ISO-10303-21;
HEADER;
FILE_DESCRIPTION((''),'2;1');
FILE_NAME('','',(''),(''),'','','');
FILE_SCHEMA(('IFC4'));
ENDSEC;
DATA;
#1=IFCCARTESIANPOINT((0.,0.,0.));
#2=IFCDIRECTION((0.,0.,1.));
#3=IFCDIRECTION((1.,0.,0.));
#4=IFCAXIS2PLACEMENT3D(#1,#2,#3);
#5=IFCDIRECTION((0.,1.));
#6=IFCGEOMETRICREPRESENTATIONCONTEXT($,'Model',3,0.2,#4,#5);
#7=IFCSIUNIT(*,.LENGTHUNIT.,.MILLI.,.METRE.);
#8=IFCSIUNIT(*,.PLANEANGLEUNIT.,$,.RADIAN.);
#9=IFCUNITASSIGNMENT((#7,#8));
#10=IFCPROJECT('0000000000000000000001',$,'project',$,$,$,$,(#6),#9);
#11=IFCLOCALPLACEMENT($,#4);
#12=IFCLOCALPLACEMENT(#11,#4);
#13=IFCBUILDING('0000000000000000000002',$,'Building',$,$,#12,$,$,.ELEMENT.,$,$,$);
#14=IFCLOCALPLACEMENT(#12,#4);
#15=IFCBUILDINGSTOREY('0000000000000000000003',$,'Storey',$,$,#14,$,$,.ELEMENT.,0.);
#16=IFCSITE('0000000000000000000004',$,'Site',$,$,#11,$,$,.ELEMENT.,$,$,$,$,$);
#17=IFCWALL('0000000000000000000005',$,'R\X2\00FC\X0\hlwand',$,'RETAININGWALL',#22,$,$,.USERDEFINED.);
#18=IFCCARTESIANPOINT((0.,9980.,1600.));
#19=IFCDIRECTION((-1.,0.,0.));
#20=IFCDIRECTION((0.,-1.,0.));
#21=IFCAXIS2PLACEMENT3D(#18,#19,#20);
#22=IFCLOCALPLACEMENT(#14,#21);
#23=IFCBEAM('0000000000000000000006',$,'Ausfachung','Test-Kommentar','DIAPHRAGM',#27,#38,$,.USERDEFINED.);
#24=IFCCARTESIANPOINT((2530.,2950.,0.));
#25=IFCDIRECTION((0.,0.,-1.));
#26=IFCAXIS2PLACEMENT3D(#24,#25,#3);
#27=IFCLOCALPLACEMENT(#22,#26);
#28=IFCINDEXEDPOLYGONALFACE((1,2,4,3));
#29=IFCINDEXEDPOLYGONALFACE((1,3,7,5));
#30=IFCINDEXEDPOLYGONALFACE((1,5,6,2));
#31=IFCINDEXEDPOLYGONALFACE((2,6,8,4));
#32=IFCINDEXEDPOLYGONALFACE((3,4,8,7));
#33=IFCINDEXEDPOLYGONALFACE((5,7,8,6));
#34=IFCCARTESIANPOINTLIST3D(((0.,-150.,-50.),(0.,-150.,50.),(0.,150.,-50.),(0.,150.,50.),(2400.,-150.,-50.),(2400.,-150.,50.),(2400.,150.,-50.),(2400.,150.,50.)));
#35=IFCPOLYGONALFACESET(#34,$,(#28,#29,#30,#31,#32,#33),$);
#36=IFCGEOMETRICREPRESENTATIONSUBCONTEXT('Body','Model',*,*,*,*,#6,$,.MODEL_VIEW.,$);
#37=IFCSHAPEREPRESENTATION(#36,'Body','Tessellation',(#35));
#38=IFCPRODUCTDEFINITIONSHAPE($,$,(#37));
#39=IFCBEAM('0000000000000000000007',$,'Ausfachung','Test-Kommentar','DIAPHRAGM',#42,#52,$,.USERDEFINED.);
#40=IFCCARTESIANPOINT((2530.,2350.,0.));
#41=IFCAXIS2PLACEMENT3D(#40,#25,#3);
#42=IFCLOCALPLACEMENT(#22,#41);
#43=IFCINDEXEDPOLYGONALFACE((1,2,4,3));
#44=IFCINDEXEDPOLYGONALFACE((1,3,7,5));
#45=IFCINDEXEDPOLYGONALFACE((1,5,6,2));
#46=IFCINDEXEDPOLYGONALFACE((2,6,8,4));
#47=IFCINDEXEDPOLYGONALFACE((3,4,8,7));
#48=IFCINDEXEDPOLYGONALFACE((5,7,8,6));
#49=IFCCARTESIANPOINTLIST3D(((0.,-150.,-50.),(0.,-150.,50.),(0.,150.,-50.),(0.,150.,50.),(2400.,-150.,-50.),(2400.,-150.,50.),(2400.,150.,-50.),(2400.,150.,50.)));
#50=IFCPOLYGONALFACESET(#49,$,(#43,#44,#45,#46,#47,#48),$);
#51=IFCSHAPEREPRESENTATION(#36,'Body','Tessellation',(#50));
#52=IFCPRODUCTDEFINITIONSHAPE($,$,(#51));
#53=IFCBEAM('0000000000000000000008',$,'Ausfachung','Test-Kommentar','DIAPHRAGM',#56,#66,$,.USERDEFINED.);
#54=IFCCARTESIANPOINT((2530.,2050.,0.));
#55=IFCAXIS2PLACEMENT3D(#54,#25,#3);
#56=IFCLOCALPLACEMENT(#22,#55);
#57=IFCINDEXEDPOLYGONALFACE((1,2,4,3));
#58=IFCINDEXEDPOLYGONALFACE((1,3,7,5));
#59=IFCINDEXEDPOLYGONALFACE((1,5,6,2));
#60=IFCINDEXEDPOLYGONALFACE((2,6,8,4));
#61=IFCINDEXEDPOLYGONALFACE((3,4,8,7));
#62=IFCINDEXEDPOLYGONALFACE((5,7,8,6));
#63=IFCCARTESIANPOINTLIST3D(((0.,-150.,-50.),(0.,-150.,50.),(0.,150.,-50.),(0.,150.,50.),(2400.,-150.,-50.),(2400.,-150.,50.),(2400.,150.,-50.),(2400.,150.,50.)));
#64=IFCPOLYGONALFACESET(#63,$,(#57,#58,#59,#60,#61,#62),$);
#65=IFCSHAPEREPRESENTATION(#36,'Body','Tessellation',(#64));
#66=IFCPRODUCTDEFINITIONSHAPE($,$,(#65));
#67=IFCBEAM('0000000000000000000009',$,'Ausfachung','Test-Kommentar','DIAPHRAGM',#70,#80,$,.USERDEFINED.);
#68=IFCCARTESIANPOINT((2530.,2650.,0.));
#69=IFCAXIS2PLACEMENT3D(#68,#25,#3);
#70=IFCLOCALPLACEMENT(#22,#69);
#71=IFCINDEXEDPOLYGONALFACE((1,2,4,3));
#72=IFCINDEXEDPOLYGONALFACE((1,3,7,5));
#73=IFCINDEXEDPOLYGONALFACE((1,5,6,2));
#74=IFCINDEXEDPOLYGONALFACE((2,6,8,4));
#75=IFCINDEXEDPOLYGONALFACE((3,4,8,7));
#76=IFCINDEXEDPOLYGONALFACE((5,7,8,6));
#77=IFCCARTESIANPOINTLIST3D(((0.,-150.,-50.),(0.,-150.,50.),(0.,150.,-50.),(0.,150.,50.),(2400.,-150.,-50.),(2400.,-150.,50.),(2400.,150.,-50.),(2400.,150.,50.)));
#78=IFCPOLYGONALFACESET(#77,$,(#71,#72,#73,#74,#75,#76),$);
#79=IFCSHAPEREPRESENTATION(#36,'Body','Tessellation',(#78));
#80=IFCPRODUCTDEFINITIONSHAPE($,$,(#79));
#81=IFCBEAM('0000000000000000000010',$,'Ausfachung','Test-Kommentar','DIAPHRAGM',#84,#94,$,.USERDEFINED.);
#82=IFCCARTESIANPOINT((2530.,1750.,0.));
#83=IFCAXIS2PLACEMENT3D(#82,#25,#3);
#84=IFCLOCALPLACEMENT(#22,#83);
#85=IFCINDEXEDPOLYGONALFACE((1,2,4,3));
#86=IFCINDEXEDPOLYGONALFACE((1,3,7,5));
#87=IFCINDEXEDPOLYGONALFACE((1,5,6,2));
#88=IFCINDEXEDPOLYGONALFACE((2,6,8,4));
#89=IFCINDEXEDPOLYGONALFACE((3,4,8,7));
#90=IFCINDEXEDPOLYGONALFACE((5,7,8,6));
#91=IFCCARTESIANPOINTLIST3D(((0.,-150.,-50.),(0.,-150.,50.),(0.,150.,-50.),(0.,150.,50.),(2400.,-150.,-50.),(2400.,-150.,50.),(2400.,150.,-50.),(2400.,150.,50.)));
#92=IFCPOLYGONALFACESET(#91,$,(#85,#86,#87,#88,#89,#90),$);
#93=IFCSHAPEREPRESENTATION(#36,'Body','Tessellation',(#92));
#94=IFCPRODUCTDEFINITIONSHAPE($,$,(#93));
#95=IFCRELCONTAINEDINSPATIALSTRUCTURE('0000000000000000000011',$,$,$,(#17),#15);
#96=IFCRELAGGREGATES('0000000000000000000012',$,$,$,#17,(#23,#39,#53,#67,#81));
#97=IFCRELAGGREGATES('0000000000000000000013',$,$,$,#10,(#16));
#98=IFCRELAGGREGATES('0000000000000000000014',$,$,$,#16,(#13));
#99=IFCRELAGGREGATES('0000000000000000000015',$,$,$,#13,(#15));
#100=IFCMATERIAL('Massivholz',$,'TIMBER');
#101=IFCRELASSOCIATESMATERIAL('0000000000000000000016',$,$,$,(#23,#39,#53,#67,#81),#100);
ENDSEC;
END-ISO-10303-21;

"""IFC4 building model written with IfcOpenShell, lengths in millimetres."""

from ifc_helpers import new_model, si_unit, direction, frame, origin_with_axes, place, context, subcontext, project, spatial, line, indexed_curve, outline, extrude, material, element, aggregate, save


model = new_model("IFC4")

# Units and contexts
model_context = context("Model", 3, precision=0.2, world=origin_with_axes(), true_north=direction((0.0, 1.0)))
body_context = subcontext(model_context, "Body", "Model", "MODEL_VIEW")
ifc_project = project(units=[si_unit("LENGTHUNIT", "METRE", prefix="MILLI"), si_unit("PLANEANGLEUNIT", "RADIAN")], contexts=[model_context])

# Site, building, storey
site_placement = place(None, origin_with_axes())
site = spatial("IfcSite", under=ifc_project, at=site_placement, Name="Site", CompositionType="ELEMENT")
building_placement = place(site_placement, origin_with_axes())
building = spatial("IfcBuilding", under=site, at=building_placement, Name="Building", CompositionType="ELEMENT")
storey_placement = place(building_placement, origin_with_axes())
storey = spatial("IfcBuildingStorey", under=building, at=storey_placement, Name="Storey", CompositionType="ELEMENT", Elevation=0.0)

# Wall, beams
wall_placement = place(storey_placement, frame((0.0, 9980.0, 1600.0), z_axis=(-1.0, 0.0, 0.0), x_axis=(0.0, -1.0, 0.0)))
wall = element("IfcWall", 1, at=wall_placement, inside=storey, Name="Rühlwand", ObjectType="RETAININGWALL", PredefinedType="USERDEFINED")
ifc_material_1 = material(Name="Massivholz", Category="TIMBER")
beam_1_placement = place(wall_placement, frame((2530.0, 2950.0, 0.0), z_axis=(0.0, 0.0, -1.0), x_axis=(1.0, 0.0, 0.0)))
beam_1 = element("IfcBeam", 2, at=beam_1_placement, material=ifc_material_1, Name="Ausfachung", Description="Test-Kommentar", ObjectType="DIAPHRAGM", PredefinedType="USERDEFINED", context=body_context, shape_type="SolidModel", body=[
    extrude(outline(indexed_curve([(-50.0, -150.0), (50.0, -150.0), (50.0, 150.0), (-50.0, 150.0)], segments=[line(1, 2, 3, 4, 1)])), frame((0.0, 0.0, 0.0), z_axis=(-1.0, 0.0, 0.0), x_axis=(0.0, 0.0, 1.0)), (0.0, 0.0, -1.0), 2400.0),
])
beam_2_placement = place(wall_placement, frame((2530.0, 2350.0, 0.0), z_axis=(0.0, 0.0, -1.0), x_axis=(1.0, 0.0, 0.0)))
beam_2 = element("IfcBeam", 3, at=beam_2_placement, material=ifc_material_1, Name="Ausfachung", Description="Test-Kommentar", ObjectType="DIAPHRAGM", PredefinedType="USERDEFINED", context=body_context, shape_type="SolidModel", body=[
    extrude(outline(indexed_curve([(-50.0, -150.0), (50.0, -150.0), (50.0, 150.0), (-50.0, 150.0)], segments=[line(1, 2, 3, 4, 1)])), frame((0.0, 0.0, 0.0), z_axis=(-1.0, 0.0, 0.0), x_axis=(0.0, 0.0, 1.0)), (0.0, 0.0, -1.0), 2400.0),
])
beam_3_placement = place(wall_placement, frame((2530.0, 2050.0, 0.0), z_axis=(0.0, 0.0, -1.0), x_axis=(1.0, 0.0, 0.0)))
beam_3 = element("IfcBeam", 4, at=beam_3_placement, material=ifc_material_1, Name="Ausfachung", Description="Test-Kommentar", ObjectType="DIAPHRAGM", PredefinedType="USERDEFINED", context=body_context, shape_type="SolidModel", body=[
    extrude(outline(indexed_curve([(-50.0, -150.0), (50.0, -150.0), (50.0, 150.0), (-50.0, 150.0)], segments=[line(1, 2, 3, 4, 1)])), frame((0.0, 0.0, 0.0), z_axis=(-1.0, 0.0, 0.0), x_axis=(0.0, 0.0, 1.0)), (0.0, 0.0, -1.0), 2400.0),
])
beam_4_placement = place(wall_placement, frame((2530.0, 2650.0, 0.0), z_axis=(0.0, 0.0, -1.0), x_axis=(1.0, 0.0, 0.0)))
beam_4 = element("IfcBeam", 5, at=beam_4_placement, material=ifc_material_1, Name="Ausfachung", Description="Test-Kommentar", ObjectType="DIAPHRAGM", PredefinedType="USERDEFINED", context=body_context, shape_type="SolidModel", body=[
    extrude(outline(indexed_curve([(-50.0, -150.0), (50.0, -150.0), (50.0, 150.0), (-50.0, 150.0)], segments=[line(1, 2, 3, 4, 1)])), frame((0.0, 0.0, 0.0), z_axis=(-1.0, 0.0, 0.0), x_axis=(0.0, 0.0, 1.0)), (0.0, 0.0, -1.0), 2400.0),
])
beam_5_placement = place(wall_placement, frame((2530.0, 1750.0, 0.0), z_axis=(0.0, 0.0, -1.0), x_axis=(1.0, 0.0, 0.0)))
beam_5 = element("IfcBeam", 6, at=beam_5_placement, material=ifc_material_1, Name="Ausfachung", Description="Test-Kommentar", ObjectType="DIAPHRAGM", PredefinedType="USERDEFINED", context=body_context, shape_type="SolidModel", body=[
    extrude(outline(indexed_curve([(-50.0, -150.0), (50.0, -150.0), (50.0, 150.0), (-50.0, 150.0)], segments=[line(1, 2, 3, 4, 1)])), frame((0.0, 0.0, 0.0), z_axis=(-1.0, 0.0, 0.0), x_axis=(0.0, 0.0, 1.0)), (0.0, 0.0, -1.0), 2400.0),
])
aggregate(wall, [beam_1, beam_2, beam_3, beam_4, beam_5])

save(model, "model.ifc")
